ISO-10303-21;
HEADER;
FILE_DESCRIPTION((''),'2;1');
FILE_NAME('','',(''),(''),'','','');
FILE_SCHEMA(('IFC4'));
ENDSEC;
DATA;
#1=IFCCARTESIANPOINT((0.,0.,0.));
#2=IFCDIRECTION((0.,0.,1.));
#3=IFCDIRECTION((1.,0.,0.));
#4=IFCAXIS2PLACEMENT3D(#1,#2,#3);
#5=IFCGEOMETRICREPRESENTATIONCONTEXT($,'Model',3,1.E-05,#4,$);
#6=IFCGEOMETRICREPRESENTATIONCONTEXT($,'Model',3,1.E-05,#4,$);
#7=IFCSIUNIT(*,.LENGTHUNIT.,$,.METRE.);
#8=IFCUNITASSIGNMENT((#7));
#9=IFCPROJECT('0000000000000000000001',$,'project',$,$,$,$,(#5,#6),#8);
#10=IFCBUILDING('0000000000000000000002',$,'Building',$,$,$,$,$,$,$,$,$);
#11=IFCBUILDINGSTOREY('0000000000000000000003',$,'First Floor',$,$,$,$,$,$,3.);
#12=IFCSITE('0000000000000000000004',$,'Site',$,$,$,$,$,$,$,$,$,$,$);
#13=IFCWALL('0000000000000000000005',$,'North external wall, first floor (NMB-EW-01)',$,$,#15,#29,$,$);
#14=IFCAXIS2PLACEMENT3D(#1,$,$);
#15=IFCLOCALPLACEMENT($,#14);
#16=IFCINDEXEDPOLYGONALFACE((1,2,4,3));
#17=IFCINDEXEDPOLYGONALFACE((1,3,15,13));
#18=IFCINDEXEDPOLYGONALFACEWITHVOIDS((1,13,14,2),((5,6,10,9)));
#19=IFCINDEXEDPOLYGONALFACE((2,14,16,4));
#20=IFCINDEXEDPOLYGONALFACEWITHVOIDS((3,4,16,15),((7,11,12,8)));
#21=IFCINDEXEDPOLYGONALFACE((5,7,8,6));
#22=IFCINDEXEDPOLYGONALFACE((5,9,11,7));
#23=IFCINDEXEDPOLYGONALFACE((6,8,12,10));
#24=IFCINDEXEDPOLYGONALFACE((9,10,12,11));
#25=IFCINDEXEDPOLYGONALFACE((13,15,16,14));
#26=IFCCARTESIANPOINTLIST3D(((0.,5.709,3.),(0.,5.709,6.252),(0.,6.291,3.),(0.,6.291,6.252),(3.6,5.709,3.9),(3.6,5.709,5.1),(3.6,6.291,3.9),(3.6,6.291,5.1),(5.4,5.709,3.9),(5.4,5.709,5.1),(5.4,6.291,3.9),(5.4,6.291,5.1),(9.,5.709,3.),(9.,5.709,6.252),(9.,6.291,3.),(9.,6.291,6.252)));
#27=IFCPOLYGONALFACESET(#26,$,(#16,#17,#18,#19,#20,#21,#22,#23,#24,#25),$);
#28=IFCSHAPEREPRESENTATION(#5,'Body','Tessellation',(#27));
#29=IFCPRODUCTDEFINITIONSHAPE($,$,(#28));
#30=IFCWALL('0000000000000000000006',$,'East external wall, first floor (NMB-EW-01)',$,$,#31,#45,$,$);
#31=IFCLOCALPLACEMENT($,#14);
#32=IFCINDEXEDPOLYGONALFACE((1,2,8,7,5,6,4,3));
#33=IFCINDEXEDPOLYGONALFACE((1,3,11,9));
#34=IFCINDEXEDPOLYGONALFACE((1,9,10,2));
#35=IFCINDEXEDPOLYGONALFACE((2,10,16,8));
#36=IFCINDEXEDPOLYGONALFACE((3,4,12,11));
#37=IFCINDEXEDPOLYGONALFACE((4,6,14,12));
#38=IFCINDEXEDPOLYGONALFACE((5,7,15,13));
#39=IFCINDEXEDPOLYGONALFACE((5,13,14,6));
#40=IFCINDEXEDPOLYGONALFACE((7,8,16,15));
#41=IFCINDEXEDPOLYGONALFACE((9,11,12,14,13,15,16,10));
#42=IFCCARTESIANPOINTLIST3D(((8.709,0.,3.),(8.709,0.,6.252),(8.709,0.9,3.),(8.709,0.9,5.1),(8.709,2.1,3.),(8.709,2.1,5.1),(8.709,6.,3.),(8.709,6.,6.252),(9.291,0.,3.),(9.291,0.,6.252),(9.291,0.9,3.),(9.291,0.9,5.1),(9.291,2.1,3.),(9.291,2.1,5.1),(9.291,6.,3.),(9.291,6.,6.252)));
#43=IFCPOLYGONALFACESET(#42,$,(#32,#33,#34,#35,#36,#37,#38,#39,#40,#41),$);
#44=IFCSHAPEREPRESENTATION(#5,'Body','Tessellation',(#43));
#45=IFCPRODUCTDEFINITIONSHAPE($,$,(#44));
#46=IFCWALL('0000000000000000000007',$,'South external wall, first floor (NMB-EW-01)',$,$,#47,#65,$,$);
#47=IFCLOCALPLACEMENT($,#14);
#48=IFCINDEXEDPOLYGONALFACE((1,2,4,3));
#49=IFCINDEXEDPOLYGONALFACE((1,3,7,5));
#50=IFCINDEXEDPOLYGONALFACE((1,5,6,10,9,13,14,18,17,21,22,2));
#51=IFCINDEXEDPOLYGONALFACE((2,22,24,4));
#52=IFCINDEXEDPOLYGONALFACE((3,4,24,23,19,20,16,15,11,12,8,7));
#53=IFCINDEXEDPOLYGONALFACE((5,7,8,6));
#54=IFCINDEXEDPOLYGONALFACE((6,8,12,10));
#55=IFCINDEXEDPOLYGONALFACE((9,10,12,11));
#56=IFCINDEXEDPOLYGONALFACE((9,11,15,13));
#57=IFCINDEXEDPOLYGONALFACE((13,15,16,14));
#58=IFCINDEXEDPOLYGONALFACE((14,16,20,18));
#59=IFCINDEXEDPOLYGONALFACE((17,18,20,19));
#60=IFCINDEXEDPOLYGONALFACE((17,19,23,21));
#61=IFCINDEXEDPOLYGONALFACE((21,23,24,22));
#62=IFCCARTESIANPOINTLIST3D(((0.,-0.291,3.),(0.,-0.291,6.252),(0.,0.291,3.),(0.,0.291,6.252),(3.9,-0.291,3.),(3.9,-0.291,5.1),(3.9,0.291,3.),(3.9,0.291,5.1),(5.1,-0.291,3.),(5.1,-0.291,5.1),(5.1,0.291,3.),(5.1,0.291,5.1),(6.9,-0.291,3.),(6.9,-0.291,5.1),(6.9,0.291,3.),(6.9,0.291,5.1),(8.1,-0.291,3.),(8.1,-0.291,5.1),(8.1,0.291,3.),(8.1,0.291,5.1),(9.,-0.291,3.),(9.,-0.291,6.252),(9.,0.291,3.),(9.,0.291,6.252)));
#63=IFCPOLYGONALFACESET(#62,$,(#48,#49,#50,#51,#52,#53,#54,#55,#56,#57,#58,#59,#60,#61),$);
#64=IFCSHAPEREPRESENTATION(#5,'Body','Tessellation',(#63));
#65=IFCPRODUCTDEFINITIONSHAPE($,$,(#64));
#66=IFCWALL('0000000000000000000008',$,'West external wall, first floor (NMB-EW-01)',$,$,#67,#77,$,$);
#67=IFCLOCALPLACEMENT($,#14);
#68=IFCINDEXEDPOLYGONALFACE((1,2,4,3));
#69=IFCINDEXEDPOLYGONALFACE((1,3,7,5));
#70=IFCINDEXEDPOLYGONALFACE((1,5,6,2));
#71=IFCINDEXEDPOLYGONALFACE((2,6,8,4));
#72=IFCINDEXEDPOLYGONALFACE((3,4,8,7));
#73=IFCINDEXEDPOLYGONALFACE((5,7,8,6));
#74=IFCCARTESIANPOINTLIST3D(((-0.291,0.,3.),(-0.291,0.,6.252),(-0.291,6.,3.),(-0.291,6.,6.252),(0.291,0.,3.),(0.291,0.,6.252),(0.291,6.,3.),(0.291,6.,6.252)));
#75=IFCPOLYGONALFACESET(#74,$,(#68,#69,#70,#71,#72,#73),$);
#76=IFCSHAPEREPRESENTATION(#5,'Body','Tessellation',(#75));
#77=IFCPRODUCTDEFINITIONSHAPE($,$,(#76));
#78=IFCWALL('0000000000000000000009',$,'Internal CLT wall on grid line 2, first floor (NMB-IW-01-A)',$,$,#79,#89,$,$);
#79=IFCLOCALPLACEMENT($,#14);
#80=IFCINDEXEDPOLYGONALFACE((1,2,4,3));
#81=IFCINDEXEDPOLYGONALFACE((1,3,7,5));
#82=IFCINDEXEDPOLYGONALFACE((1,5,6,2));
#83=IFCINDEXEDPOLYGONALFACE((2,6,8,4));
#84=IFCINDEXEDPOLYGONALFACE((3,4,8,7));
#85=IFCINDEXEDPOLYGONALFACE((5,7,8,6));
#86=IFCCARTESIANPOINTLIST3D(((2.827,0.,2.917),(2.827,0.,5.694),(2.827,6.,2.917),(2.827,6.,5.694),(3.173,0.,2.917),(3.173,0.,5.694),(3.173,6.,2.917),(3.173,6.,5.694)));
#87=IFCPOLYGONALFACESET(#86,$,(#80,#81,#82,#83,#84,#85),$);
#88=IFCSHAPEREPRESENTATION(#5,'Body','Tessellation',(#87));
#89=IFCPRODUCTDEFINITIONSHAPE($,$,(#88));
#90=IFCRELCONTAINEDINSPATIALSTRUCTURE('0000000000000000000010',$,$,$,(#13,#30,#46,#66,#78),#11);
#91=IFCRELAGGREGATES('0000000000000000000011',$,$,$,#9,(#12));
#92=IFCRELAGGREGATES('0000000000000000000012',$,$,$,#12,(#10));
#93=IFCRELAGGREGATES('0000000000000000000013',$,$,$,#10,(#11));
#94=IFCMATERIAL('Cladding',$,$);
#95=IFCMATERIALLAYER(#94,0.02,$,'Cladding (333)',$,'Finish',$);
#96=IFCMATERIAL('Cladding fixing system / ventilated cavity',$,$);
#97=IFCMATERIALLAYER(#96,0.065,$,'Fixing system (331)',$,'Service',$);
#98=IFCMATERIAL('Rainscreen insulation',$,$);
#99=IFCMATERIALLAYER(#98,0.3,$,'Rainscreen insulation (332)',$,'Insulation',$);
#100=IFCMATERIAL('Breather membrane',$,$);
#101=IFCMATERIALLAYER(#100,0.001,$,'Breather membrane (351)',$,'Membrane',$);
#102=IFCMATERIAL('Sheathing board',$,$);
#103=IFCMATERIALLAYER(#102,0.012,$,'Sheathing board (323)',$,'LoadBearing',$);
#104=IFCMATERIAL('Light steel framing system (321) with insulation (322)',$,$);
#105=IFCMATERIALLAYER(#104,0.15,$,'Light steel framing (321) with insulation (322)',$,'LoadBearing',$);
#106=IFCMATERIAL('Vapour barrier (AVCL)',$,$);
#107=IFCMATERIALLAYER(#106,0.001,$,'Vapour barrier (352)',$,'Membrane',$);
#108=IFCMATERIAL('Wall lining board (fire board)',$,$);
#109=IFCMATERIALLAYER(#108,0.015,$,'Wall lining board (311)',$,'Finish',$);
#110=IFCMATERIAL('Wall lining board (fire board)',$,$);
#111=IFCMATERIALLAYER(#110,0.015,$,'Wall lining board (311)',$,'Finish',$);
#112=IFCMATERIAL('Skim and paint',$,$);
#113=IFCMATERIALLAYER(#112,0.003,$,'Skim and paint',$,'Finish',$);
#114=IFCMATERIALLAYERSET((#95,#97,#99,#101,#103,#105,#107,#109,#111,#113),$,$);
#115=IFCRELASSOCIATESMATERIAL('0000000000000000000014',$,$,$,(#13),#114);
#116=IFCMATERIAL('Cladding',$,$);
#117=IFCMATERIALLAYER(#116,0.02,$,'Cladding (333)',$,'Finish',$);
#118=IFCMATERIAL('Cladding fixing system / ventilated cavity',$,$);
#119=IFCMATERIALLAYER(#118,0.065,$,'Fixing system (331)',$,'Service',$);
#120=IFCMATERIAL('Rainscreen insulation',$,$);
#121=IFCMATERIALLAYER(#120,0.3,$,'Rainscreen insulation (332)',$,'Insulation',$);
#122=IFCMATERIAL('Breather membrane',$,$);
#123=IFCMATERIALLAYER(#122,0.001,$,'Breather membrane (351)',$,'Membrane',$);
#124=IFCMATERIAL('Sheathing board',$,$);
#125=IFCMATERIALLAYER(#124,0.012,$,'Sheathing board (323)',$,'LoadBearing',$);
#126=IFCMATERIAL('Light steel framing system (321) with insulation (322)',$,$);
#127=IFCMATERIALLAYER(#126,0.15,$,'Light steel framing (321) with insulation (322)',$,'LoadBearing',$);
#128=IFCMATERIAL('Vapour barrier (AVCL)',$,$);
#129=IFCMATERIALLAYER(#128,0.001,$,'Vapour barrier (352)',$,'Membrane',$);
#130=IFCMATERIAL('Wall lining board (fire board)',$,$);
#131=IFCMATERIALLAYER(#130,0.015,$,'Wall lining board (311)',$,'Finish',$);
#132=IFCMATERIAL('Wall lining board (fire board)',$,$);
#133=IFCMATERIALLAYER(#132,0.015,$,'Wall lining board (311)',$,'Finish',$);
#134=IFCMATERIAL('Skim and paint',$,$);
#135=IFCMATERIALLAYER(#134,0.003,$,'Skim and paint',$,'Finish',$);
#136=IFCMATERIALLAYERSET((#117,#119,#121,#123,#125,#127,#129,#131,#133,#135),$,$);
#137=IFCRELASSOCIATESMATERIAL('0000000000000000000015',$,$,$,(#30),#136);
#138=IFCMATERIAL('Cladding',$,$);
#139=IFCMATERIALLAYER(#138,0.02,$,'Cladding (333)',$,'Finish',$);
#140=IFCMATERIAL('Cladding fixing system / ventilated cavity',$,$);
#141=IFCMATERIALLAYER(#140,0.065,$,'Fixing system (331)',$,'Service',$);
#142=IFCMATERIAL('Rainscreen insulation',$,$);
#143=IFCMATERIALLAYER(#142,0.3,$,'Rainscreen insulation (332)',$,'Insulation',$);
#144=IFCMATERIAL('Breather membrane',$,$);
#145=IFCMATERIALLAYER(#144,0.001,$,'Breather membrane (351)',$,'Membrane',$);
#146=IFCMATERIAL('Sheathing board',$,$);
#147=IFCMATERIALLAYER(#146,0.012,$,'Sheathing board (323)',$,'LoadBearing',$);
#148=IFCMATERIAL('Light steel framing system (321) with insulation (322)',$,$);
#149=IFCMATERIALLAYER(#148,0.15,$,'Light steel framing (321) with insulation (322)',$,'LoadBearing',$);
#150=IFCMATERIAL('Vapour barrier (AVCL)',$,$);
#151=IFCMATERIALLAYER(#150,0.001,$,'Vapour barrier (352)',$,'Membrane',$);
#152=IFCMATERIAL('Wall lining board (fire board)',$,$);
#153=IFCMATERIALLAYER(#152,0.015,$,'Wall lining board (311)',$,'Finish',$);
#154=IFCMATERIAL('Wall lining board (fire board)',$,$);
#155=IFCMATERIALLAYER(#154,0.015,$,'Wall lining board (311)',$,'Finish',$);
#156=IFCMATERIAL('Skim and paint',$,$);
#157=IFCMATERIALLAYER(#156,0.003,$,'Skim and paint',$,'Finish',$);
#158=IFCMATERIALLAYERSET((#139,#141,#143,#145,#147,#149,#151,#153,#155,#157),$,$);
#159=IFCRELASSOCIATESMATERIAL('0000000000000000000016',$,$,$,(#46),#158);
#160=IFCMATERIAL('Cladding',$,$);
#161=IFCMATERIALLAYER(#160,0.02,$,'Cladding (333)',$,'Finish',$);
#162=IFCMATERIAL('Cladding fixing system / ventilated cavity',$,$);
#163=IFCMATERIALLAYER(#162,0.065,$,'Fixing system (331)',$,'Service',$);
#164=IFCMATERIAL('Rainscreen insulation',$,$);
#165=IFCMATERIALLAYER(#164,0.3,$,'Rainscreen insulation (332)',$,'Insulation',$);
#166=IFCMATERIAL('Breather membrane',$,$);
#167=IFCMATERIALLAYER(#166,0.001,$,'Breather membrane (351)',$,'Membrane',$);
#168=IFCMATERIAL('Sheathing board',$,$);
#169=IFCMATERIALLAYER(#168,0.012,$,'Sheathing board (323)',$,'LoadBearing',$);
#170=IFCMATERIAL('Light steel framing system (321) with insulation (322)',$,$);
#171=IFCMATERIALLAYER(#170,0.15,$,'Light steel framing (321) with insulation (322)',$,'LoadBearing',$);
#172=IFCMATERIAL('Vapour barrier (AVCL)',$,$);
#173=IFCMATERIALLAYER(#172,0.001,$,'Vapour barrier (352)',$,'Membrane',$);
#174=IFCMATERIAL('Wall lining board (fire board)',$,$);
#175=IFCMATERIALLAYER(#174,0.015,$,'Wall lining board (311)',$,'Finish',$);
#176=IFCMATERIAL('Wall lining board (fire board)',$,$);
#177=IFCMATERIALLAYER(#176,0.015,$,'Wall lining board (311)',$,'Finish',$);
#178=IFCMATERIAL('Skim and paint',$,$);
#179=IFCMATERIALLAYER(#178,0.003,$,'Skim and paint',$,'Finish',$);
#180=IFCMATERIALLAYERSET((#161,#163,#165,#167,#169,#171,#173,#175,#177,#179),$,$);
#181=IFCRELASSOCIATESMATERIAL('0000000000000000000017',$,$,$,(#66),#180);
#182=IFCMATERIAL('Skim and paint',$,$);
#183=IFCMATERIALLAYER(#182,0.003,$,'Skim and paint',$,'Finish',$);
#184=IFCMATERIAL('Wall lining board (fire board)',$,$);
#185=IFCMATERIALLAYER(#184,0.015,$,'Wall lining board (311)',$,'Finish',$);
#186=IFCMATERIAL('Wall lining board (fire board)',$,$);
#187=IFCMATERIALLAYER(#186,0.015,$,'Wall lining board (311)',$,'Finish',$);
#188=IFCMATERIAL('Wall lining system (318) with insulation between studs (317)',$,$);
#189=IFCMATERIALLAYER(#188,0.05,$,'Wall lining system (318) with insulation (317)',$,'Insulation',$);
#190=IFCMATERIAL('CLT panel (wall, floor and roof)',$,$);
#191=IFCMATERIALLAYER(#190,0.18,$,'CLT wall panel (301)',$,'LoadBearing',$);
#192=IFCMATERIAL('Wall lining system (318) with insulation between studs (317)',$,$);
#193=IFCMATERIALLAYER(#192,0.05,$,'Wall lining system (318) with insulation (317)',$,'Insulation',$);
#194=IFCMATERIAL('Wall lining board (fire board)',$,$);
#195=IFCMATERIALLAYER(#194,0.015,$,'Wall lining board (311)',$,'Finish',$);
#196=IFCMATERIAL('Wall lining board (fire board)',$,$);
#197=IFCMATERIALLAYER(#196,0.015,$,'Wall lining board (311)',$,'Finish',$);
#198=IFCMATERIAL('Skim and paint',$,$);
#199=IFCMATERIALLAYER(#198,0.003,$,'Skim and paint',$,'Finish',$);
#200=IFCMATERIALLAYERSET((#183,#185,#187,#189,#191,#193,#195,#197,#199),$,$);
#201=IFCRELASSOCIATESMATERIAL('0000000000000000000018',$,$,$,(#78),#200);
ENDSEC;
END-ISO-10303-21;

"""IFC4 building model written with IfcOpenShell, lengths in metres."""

from ifc_helpers import new_model, si_unit, frame, frame_2d, origin, origin_with_axes, origin_2d, place, context, project, spatial, rectangle, extrude, material, layer, layer_set, layer_usage, element, save


model = new_model("IFC4")

# Units and contexts
model_context_1 = context("Model", 3, precision=1e-05, world=origin_with_axes())
model_context_2 = context("Model", 3, precision=1e-05, world=origin_with_axes())
ifc_project = project(units=[si_unit("LENGTHUNIT", "METRE")], contexts=[model_context_1, model_context_2])

# Site, building, storey
site = spatial("IfcSite", under=ifc_project, Name="Site")
building = spatial("IfcBuilding", under=site, Name="Building")
storey = spatial("IfcBuildingStorey", under=building, Name="First Floor", Elevation=3.0)

# Walls, openings
ifc_material_1 = material(Name="Cladding")
ifc_layer_1 = layer(ifc_material_1, 0.02, Name="Cladding (333)", Category="Finish")
ifc_material_2 = material(Name="Cladding fixing system / ventilated cavity")
ifc_layer_2 = layer(ifc_material_2, 0.065, Name="Fixing system (331)", Category="Service")
ifc_material_3 = material(Name="Rainscreen insulation")
ifc_layer_3 = layer(ifc_material_3, 0.3, Name="Rainscreen insulation (332)", Category="Insulation")
ifc_material_4 = material(Name="Breather membrane")
ifc_layer_4 = layer(ifc_material_4, 0.001, Name="Breather membrane (351)", Category="Membrane")
ifc_material_5 = material(Name="Sheathing board")
ifc_layer_5 = layer(ifc_material_5, 0.012, Name="Sheathing board (323)", Category="LoadBearing")
ifc_material_6 = material(Name="Light steel framing system (321) with insulation (322)")
ifc_layer_6 = layer(ifc_material_6, 0.15, Name="Light steel framing (321) with insulation (322)", Category="LoadBearing")
ifc_material_7 = material(Name="Vapour barrier (AVCL)")
ifc_layer_7 = layer(ifc_material_7, 0.001, Name="Vapour barrier (352)", Category="Membrane")
ifc_material_8 = material(Name="Wall lining board (fire board)")
ifc_layer_8 = layer(ifc_material_8, 0.015, Name="Wall lining board (311)", Category="Finish")
ifc_material_9 = material(Name="Wall lining board (fire board)")
ifc_layer_9 = layer(ifc_material_9, 0.015, Name="Wall lining board (311)", Category="Finish")
ifc_material_10 = material(Name="Skim and paint")
ifc_layer_10 = layer(ifc_material_10, 0.003, Name="Skim and paint", Category="Finish")
ifc_layer_set_1 = layer_set([ifc_layer_1, ifc_layer_2, ifc_layer_3, ifc_layer_4, ifc_layer_5, ifc_layer_6, ifc_layer_7, ifc_layer_8, ifc_layer_9, ifc_layer_10])
ifc_layer_usage_1 = layer_usage(ifc_layer_set_1, "AXIS2", "NEGATIVE", 0.291)
wall_1_placement = place(None, frame((0.0, 6.0, 3.0), z_axis=(0.0, 0.0, 1.0), x_axis=(1.0, 0.0, 0.0)))
wall_1 = element("IfcWall", 1, at=wall_1_placement, inside=storey, material=ifc_layer_usage_1, Name="North external wall, first floor (NMB-EW-01)", context=model_context_1, shape_type="SweptSolid", body=[
    extrude(rectangle(XDim=0.582, YDim=3.252, at=frame_2d((0.0, 1.626))), frame((0.0, 0.0, 0.0), z_axis=(1.0, 0.0, 0.0), x_axis=(0.0, 1.0, 0.0)), (0.0, 0.0, 1.0), 9.0),
])
opening_1_placement = place(wall_1_placement, frame((4.5, 0.0, 0.9), z_axis=(0.0, 0.0, 1.0), x_axis=(1.0, 0.0, 0.0)))
element("IfcOpeningElement", 2, at=opening_1_placement, cuts=wall_1, context=model_context_1, shape_type="SweptSolid", body=[
    extrude(rectangle(XDim=1.8, YDim=0.582, at=origin_2d()), origin(), (0.0, 0.0, 1.0), 1.2),
])
ifc_material_11 = material(Name="Cladding")
ifc_layer_11 = layer(ifc_material_11, 0.02, Name="Cladding (333)", Category="Finish")
ifc_material_12 = material(Name="Cladding fixing system / ventilated cavity")
ifc_layer_12 = layer(ifc_material_12, 0.065, Name="Fixing system (331)", Category="Service")
ifc_material_13 = material(Name="Rainscreen insulation")
ifc_layer_13 = layer(ifc_material_13, 0.3, Name="Rainscreen insulation (332)", Category="Insulation")
ifc_material_14 = material(Name="Breather membrane")
ifc_layer_14 = layer(ifc_material_14, 0.001, Name="Breather membrane (351)", Category="Membrane")
ifc_material_15 = material(Name="Sheathing board")
ifc_layer_15 = layer(ifc_material_15, 0.012, Name="Sheathing board (323)", Category="LoadBearing")
ifc_material_16 = material(Name="Light steel framing system (321) with insulation (322)")
ifc_layer_16 = layer(ifc_material_16, 0.15, Name="Light steel framing (321) with insulation (322)", Category="LoadBearing")
ifc_material_17 = material(Name="Vapour barrier (AVCL)")
ifc_layer_17 = layer(ifc_material_17, 0.001, Name="Vapour barrier (352)", Category="Membrane")
ifc_material_18 = material(Name="Wall lining board (fire board)")
ifc_layer_18 = layer(ifc_material_18, 0.015, Name="Wall lining board (311)", Category="Finish")
ifc_material_19 = material(Name="Wall lining board (fire board)")
ifc_layer_19 = layer(ifc_material_19, 0.015, Name="Wall lining board (311)", Category="Finish")
ifc_material_20 = material(Name="Skim and paint")
ifc_layer_20 = layer(ifc_material_20, 0.003, Name="Skim and paint", Category="Finish")
ifc_layer_set_2 = layer_set([ifc_layer_11, ifc_layer_12, ifc_layer_13, ifc_layer_14, ifc_layer_15, ifc_layer_16, ifc_layer_17, ifc_layer_18, ifc_layer_19, ifc_layer_20])
ifc_layer_usage_2 = layer_usage(ifc_layer_set_2, "AXIS2", "NEGATIVE", 0.291)
wall_2_placement = place(None, frame((9.0, 6.0, 3.0), z_axis=(0.0, 0.0, 1.0), x_axis=(0.0, -1.0, 0.0)))
wall_2 = element("IfcWall", 3, at=wall_2_placement, inside=storey, material=ifc_layer_usage_2, Name="East external wall, first floor (NMB-EW-01)", context=model_context_1, shape_type="SweptSolid", body=[
    extrude(rectangle(XDim=0.582, YDim=3.252, at=frame_2d((0.0, 1.626))), frame((0.0, 0.0, 0.0), z_axis=(1.0, 0.0, 0.0), x_axis=(0.0, 1.0, 0.0)), (0.0, 0.0, 1.0), 6.0),
])
opening_2_placement = place(wall_2_placement, frame((4.5, 0.0, 0.0), z_axis=(0.0, 0.0, 1.0), x_axis=(1.0, 0.0, 0.0)))
element("IfcOpeningElement", 4, at=opening_2_placement, cuts=wall_2, context=model_context_1, shape_type="SweptSolid", body=[
    extrude(rectangle(XDim=1.2, YDim=0.582, at=origin_2d()), origin(), (0.0, 0.0, 1.0), 2.1),
])

# Wall, openings
ifc_material_21 = material(Name="Cladding")
ifc_layer_21 = layer(ifc_material_21, 0.02, Name="Cladding (333)", Category="Finish")
ifc_material_22 = material(Name="Cladding fixing system / ventilated cavity")
ifc_layer_22 = layer(ifc_material_22, 0.065, Name="Fixing system (331)", Category="Service")
ifc_material_23 = material(Name="Rainscreen insulation")
ifc_layer_23 = layer(ifc_material_23, 0.3, Name="Rainscreen insulation (332)", Category="Insulation")
ifc_material_24 = material(Name="Breather membrane")
ifc_layer_24 = layer(ifc_material_24, 0.001, Name="Breather membrane (351)", Category="Membrane")
ifc_material_25 = material(Name="Sheathing board")
ifc_layer_25 = layer(ifc_material_25, 0.012, Name="Sheathing board (323)", Category="LoadBearing")
ifc_material_26 = material(Name="Light steel framing system (321) with insulation (322)")
ifc_layer_26 = layer(ifc_material_26, 0.15, Name="Light steel framing (321) with insulation (322)", Category="LoadBearing")
ifc_material_27 = material(Name="Vapour barrier (AVCL)")
ifc_layer_27 = layer(ifc_material_27, 0.001, Name="Vapour barrier (352)", Category="Membrane")
ifc_material_28 = material(Name="Wall lining board (fire board)")
ifc_layer_28 = layer(ifc_material_28, 0.015, Name="Wall lining board (311)", Category="Finish")
ifc_material_29 = material(Name="Wall lining board (fire board)")
ifc_layer_29 = layer(ifc_material_29, 0.015, Name="Wall lining board (311)", Category="Finish")
ifc_material_30 = material(Name="Skim and paint")
ifc_layer_30 = layer(ifc_material_30, 0.003, Name="Skim and paint", Category="Finish")
ifc_layer_set_3 = layer_set([ifc_layer_21, ifc_layer_22, ifc_layer_23, ifc_layer_24, ifc_layer_25, ifc_layer_26, ifc_layer_27, ifc_layer_28, ifc_layer_29, ifc_layer_30])
ifc_layer_usage_3 = layer_usage(ifc_layer_set_3, "AXIS2", "NEGATIVE", 0.291)
wall_3_placement = place(None, frame((9.0, 0.0, 3.0), z_axis=(0.0, 0.0, 1.0), x_axis=(-1.0, 0.0, 0.0)))
wall_3 = element("IfcWall", 5, at=wall_3_placement, inside=storey, material=ifc_layer_usage_3, Name="South external wall, first floor (NMB-EW-01)", context=model_context_1, shape_type="SweptSolid", body=[
    extrude(rectangle(XDim=0.582, YDim=3.252, at=frame_2d((0.0, 1.626))), frame((0.0, 0.0, 0.0), z_axis=(1.0, 0.0, 0.0), x_axis=(0.0, 1.0, 0.0)), (0.0, 0.0, 1.0), 9.0),
])
opening_3_placement = place(wall_3_placement, frame((4.5, 0.0, 0.0), z_axis=(0.0, 0.0, 1.0), x_axis=(1.0, 0.0, 0.0)))
element("IfcOpeningElement", 6, at=opening_3_placement, cuts=wall_3, context=model_context_1, shape_type="SweptSolid", body=[
    extrude(rectangle(XDim=1.2, YDim=0.582, at=origin_2d()), origin(), (0.0, 0.0, 1.0), 2.1),
])
opening_4_placement = place(wall_3_placement, frame((1.5, 0.0, 0.0), z_axis=(0.0, 0.0, 1.0), x_axis=(1.0, 0.0, 0.0)))
element("IfcOpeningElement", 7, at=opening_4_placement, cuts=wall_3, context=model_context_1, shape_type="SweptSolid", body=[
    extrude(rectangle(XDim=1.2, YDim=0.582, at=origin_2d()), origin(), (0.0, 0.0, 1.0), 2.1),
])

# Walls
ifc_material_31 = material(Name="Cladding")
ifc_layer_31 = layer(ifc_material_31, 0.02, Name="Cladding (333)", Category="Finish")
ifc_material_32 = material(Name="Cladding fixing system / ventilated cavity")
ifc_layer_32 = layer(ifc_material_32, 0.065, Name="Fixing system (331)", Category="Service")
ifc_material_33 = material(Name="Rainscreen insulation")
ifc_layer_33 = layer(ifc_material_33, 0.3, Name="Rainscreen insulation (332)", Category="Insulation")
ifc_material_34 = material(Name="Breather membrane")
ifc_layer_34 = layer(ifc_material_34, 0.001, Name="Breather membrane (351)", Category="Membrane")
ifc_material_35 = material(Name="Sheathing board")
ifc_layer_35 = layer(ifc_material_35, 0.012, Name="Sheathing board (323)", Category="LoadBearing")
ifc_material_36 = material(Name="Light steel framing system (321) with insulation (322)")
ifc_layer_36 = layer(ifc_material_36, 0.15, Name="Light steel framing (321) with insulation (322)", Category="LoadBearing")
ifc_material_37 = material(Name="Vapour barrier (AVCL)")
ifc_layer_37 = layer(ifc_material_37, 0.001, Name="Vapour barrier (352)", Category="Membrane")
ifc_material_38 = material(Name="Wall lining board (fire board)")
ifc_layer_38 = layer(ifc_material_38, 0.015, Name="Wall lining board (311)", Category="Finish")
ifc_material_39 = material(Name="Wall lining board (fire board)")
ifc_layer_39 = layer(ifc_material_39, 0.015, Name="Wall lining board (311)", Category="Finish")
ifc_material_40 = material(Name="Skim and paint")
ifc_layer_40 = layer(ifc_material_40, 0.003, Name="Skim and paint", Category="Finish")
ifc_layer_set_4 = layer_set([ifc_layer_31, ifc_layer_32, ifc_layer_33, ifc_layer_34, ifc_layer_35, ifc_layer_36, ifc_layer_37, ifc_layer_38, ifc_layer_39, ifc_layer_40])
ifc_layer_usage_4 = layer_usage(ifc_layer_set_4, "AXIS2", "NEGATIVE", 0.291)
wall_4_placement = place(None, frame((0.0, 0.0, 3.0), z_axis=(0.0, 0.0, 1.0), x_axis=(0.0, 1.0, 0.0)))
element("IfcWall", 8, at=wall_4_placement, inside=storey, material=ifc_layer_usage_4, Name="West external wall, first floor (NMB-EW-01)", context=model_context_1, shape_type="SweptSolid", body=[
    extrude(rectangle(XDim=0.582, YDim=3.252, at=frame_2d((0.0, 1.626))), frame((0.0, 0.0, 0.0), z_axis=(1.0, 0.0, 0.0), x_axis=(0.0, 1.0, 0.0)), (0.0, 0.0, 1.0), 6.0),
])
ifc_material_41 = material(Name="Skim and paint")
ifc_layer_41 = layer(ifc_material_41, 0.003, Name="Skim and paint", Category="Finish")
ifc_material_42 = material(Name="Wall lining board (fire board)")
ifc_layer_42 = layer(ifc_material_42, 0.015, Name="Wall lining board (311)", Category="Finish")
ifc_material_43 = material(Name="Wall lining board (fire board)")
ifc_layer_43 = layer(ifc_material_43, 0.015, Name="Wall lining board (311)", Category="Finish")
ifc_material_44 = material(Name="Wall lining system (318) with insulation between studs (317)")
ifc_layer_44 = layer(ifc_material_44, 0.05, Name="Wall lining system (318) with insulation (317)", Category="Insulation")
ifc_material_45 = material(Name="CLT panel (wall, floor and roof)")
ifc_layer_45 = layer(ifc_material_45, 0.18, Name="CLT wall panel (301)", Category="LoadBearing")
ifc_material_46 = material(Name="Wall lining system (318) with insulation between studs (317)")
ifc_layer_46 = layer(ifc_material_46, 0.05, Name="Wall lining system (318) with insulation (317)", Category="Insulation")
ifc_material_47 = material(Name="Wall lining board (fire board)")
ifc_layer_47 = layer(ifc_material_47, 0.015, Name="Wall lining board (311)", Category="Finish")
ifc_material_48 = material(Name="Wall lining board (fire board)")
ifc_layer_48 = layer(ifc_material_48, 0.015, Name="Wall lining board (311)", Category="Finish")
ifc_material_49 = material(Name="Skim and paint")
ifc_layer_49 = layer(ifc_material_49, 0.003, Name="Skim and paint", Category="Finish")
ifc_layer_set_5 = layer_set([ifc_layer_41, ifc_layer_42, ifc_layer_43, ifc_layer_44, ifc_layer_45, ifc_layer_46, ifc_layer_47, ifc_layer_48, ifc_layer_49])
ifc_layer_usage_5 = layer_usage(ifc_layer_set_5, "AXIS2", "NEGATIVE", 0.173)
wall_5_placement = place(None, frame((3.0, 0.0, 2.917), z_axis=(0.0, 0.0, 1.0), x_axis=(0.0, 1.0, 0.0)))
element("IfcWall", 9, at=wall_5_placement, inside=storey, material=ifc_layer_usage_5, Name="Internal CLT wall on grid line 2, first floor (NMB-IW-01-A)", context=model_context_1, shape_type="SweptSolid", body=[
    extrude(rectangle(XDim=0.346, YDim=2.777, at=frame_2d((0.0, 1.3885))), frame((0.0, 0.0, 0.0), z_axis=(1.0, 0.0, 0.0), x_axis=(0.0, 1.0, 0.0)), (0.0, 0.0, 1.0), 6.0),
])

save(model, "model.ifc")
